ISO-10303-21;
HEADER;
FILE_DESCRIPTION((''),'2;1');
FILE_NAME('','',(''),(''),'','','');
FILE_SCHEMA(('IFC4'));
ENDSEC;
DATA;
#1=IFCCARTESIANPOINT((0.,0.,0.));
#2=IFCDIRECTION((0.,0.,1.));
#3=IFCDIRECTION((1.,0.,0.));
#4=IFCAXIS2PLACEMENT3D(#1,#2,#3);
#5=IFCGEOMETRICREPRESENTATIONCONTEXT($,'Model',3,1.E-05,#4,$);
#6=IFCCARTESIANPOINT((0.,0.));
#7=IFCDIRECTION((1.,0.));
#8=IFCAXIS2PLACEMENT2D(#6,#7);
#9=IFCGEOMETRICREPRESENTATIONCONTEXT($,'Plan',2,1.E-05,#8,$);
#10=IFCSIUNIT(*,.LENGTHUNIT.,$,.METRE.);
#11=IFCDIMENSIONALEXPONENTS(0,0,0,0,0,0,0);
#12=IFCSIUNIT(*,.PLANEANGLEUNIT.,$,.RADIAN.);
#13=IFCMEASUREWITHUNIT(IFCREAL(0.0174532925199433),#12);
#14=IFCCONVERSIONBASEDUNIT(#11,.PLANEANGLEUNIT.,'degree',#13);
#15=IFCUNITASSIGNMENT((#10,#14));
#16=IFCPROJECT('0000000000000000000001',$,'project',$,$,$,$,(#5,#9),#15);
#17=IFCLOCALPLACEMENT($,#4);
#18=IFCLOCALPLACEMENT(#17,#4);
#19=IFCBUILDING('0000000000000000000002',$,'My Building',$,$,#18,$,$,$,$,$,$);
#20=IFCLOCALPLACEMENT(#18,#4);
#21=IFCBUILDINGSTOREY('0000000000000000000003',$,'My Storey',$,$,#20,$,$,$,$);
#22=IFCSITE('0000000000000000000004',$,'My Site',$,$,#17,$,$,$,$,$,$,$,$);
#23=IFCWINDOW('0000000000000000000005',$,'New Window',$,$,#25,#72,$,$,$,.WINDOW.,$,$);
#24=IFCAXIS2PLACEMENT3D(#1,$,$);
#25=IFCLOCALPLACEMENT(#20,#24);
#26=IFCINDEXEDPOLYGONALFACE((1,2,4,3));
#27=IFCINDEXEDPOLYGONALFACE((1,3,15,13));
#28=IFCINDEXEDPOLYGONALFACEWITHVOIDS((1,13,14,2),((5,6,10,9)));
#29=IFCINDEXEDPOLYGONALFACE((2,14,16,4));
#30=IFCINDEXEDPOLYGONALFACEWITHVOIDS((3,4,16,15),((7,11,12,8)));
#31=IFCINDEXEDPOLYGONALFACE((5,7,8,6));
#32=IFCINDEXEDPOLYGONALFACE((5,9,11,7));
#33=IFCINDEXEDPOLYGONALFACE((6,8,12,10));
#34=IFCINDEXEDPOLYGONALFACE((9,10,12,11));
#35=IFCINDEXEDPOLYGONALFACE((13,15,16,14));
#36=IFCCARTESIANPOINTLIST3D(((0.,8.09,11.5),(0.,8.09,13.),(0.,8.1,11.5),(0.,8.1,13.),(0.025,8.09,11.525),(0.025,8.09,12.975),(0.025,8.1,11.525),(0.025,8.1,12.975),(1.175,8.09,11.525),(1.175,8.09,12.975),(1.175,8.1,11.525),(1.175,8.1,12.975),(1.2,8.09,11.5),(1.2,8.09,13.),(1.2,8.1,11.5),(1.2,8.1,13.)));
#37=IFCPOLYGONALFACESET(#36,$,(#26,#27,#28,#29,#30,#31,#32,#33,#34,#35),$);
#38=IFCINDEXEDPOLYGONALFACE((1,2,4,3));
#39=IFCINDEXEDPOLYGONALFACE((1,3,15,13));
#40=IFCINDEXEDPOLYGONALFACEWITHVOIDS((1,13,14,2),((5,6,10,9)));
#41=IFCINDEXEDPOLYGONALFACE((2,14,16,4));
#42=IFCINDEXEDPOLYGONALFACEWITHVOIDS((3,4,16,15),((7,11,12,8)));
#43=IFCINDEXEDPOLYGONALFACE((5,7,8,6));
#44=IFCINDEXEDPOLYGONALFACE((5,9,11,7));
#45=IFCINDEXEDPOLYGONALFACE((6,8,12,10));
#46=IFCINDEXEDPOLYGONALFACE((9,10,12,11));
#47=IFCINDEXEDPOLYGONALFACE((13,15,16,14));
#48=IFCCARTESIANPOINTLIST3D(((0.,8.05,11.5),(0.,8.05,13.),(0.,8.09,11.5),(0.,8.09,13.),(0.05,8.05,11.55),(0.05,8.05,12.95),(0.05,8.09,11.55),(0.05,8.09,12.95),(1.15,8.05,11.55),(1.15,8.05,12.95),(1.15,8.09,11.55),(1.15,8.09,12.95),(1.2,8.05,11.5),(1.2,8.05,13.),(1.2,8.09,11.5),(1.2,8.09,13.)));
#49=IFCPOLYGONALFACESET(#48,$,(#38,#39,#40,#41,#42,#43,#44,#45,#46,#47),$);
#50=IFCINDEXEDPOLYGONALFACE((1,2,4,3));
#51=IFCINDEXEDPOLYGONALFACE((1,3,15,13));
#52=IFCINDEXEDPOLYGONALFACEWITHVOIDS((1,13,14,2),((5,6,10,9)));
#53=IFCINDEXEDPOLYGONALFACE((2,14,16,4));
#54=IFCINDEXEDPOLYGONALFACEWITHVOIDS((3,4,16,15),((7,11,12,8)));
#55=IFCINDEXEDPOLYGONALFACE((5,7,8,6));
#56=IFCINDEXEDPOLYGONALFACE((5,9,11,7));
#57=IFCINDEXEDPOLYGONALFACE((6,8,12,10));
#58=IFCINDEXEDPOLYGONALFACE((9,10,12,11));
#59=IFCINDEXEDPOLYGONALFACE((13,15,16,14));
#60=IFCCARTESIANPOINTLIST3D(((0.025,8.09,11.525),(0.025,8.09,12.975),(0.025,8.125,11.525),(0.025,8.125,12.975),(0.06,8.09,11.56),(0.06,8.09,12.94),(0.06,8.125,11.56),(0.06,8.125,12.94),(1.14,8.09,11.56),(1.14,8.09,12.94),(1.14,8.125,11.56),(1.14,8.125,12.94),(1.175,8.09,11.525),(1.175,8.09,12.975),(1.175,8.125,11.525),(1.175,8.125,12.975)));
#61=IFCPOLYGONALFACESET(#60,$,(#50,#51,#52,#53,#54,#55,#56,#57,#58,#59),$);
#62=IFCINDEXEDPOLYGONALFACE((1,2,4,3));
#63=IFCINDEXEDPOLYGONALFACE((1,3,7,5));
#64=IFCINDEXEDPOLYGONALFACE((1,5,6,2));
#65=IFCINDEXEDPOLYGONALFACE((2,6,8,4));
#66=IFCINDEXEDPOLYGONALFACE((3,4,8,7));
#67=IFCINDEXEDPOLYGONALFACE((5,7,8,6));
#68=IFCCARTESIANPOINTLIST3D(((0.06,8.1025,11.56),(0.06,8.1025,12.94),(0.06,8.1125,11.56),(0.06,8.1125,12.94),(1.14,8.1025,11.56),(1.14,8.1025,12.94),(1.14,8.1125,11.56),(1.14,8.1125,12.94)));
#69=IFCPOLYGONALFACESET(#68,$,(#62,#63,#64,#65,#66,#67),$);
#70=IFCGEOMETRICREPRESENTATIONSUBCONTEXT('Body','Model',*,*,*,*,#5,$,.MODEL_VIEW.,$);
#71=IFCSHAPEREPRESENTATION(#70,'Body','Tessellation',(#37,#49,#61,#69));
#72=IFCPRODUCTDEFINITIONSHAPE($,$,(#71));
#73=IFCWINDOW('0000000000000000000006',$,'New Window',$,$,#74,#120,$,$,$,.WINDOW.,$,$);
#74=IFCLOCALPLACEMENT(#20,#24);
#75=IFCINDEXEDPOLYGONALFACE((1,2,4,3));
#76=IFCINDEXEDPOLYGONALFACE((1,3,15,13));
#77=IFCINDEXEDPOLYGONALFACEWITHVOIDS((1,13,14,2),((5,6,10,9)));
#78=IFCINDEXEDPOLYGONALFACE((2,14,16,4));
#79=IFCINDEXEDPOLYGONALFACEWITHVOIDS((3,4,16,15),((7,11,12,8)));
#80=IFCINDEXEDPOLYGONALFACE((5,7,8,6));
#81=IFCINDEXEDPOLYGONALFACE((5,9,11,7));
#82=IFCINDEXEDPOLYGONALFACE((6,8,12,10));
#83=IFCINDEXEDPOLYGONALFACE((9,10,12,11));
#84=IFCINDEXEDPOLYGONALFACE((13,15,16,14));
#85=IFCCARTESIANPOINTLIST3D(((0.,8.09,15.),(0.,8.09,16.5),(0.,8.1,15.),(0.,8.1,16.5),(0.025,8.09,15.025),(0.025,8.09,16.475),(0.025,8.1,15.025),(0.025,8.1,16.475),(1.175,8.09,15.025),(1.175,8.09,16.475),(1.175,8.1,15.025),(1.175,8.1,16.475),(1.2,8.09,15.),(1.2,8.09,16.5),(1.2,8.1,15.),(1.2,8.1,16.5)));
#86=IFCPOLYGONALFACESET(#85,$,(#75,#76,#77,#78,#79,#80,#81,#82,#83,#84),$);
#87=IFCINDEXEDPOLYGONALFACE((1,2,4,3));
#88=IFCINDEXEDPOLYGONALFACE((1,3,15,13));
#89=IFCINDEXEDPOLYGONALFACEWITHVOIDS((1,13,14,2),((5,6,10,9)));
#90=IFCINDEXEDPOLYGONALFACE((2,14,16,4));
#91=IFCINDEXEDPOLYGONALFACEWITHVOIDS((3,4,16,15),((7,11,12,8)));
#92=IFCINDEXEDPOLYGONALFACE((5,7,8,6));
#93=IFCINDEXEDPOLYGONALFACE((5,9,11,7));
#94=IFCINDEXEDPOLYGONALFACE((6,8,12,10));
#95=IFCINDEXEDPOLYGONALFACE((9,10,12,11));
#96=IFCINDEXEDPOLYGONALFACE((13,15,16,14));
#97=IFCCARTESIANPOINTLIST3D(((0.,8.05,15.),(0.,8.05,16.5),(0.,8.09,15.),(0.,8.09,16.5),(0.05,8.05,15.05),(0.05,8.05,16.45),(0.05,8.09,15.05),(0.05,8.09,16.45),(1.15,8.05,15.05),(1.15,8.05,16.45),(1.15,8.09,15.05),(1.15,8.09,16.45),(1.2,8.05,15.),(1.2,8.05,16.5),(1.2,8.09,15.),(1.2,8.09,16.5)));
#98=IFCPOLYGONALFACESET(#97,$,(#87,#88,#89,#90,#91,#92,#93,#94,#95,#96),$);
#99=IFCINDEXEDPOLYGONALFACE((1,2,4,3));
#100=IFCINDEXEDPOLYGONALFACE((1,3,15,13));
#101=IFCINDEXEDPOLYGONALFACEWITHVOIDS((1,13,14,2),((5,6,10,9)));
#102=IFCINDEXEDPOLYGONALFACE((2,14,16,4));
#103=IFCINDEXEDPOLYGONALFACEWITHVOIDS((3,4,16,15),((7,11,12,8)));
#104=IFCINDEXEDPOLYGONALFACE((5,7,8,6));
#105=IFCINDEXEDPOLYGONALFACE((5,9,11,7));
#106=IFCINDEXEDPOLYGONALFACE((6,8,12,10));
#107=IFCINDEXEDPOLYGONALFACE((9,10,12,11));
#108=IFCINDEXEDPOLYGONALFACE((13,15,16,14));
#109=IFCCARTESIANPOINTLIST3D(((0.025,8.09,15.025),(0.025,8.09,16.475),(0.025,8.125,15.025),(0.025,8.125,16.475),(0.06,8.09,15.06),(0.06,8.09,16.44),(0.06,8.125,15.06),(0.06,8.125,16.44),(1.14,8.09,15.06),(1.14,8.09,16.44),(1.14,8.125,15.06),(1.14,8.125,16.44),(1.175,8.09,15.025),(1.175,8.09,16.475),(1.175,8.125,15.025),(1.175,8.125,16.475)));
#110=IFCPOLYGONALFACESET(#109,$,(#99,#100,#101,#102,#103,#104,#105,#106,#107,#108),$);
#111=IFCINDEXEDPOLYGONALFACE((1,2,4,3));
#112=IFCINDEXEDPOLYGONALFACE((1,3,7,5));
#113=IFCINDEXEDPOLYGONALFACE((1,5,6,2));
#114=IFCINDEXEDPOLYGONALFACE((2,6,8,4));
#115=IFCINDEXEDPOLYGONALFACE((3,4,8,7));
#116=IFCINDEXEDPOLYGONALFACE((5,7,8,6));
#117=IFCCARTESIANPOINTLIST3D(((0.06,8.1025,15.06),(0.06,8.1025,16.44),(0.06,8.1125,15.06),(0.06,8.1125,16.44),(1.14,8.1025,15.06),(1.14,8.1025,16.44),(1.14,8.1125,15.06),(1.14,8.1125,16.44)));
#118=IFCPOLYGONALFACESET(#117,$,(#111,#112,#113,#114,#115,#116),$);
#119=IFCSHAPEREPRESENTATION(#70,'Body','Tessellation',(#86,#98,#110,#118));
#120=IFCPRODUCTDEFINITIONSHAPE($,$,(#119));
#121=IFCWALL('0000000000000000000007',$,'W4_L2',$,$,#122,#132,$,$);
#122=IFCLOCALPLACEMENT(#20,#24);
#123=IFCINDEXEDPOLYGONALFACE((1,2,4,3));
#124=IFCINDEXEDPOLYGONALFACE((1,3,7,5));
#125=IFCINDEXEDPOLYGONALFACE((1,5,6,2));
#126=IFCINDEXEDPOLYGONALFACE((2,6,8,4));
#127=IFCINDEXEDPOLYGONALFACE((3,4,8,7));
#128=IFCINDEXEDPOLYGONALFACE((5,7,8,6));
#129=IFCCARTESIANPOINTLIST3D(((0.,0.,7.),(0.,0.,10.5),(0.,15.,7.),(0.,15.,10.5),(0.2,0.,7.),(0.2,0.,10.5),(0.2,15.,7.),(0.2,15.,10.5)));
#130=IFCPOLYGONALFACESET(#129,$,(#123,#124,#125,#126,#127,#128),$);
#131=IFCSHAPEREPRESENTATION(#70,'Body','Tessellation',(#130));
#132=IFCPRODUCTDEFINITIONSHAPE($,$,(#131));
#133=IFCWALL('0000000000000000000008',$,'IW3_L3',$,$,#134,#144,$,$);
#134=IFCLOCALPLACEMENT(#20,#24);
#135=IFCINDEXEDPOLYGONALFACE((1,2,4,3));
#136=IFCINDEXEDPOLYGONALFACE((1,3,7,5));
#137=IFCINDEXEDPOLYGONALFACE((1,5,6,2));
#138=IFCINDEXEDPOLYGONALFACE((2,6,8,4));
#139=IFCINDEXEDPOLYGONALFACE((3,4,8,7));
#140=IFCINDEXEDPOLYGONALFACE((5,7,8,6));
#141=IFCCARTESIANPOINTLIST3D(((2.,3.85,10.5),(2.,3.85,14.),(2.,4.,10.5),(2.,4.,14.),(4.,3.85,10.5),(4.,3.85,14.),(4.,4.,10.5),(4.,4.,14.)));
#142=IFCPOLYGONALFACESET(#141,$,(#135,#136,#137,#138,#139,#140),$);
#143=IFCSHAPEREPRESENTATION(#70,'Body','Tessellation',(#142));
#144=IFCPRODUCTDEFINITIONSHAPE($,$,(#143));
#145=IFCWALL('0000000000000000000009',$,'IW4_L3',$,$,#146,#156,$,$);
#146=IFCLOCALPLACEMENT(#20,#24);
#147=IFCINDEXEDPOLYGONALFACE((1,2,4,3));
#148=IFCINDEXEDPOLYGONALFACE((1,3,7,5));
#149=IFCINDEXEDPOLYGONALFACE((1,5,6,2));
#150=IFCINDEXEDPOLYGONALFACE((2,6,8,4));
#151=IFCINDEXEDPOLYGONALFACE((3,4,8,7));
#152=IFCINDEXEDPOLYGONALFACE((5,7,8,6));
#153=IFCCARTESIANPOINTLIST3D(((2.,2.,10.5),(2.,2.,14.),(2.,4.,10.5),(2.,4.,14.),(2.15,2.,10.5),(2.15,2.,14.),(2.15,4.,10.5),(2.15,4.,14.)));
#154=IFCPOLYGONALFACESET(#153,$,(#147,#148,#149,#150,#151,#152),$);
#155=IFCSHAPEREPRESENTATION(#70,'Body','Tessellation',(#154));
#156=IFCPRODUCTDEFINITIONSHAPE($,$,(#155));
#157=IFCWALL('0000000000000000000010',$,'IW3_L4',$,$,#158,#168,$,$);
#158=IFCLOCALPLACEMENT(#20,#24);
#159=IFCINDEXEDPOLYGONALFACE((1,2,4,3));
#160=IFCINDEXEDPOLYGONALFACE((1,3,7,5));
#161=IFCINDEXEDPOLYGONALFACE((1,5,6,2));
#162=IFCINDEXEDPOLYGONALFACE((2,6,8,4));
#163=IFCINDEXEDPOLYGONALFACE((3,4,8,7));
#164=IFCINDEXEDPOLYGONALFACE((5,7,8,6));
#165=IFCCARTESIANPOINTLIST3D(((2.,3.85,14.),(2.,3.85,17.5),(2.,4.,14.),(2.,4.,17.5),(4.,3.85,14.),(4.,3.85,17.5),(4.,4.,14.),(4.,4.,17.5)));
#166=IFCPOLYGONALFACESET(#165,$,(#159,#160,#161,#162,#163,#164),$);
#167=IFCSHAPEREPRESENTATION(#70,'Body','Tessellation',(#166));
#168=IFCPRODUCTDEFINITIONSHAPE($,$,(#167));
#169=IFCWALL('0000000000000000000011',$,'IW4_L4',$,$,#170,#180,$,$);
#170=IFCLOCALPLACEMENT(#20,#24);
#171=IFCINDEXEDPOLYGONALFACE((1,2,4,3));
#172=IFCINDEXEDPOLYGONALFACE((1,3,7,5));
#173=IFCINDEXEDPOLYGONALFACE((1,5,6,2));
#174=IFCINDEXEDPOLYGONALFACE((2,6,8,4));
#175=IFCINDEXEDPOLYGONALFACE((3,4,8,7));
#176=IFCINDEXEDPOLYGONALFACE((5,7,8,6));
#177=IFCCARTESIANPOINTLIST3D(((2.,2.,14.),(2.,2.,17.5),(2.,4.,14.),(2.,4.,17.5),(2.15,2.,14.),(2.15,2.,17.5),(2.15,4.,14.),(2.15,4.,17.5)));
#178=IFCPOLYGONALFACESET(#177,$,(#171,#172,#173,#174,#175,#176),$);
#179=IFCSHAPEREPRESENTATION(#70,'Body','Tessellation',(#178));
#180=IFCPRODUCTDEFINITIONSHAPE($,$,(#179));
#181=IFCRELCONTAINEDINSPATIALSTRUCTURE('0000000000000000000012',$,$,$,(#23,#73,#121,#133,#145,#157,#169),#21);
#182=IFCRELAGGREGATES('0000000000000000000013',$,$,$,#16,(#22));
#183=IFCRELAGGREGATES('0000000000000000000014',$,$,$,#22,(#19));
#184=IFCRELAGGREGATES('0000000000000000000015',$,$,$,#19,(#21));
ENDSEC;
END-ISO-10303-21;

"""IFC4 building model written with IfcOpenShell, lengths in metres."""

from ifc_helpers import new_model, entity, si_unit, converted_unit, frame, origin_with_axes, origin_2d_with_axis, place, context, subcontext, project, spatial, line, indexed_curve, outline, extrude, element, save


model = new_model("IFC4")

# Units and contexts
model_context = context("Model", 3, precision=1e-05, world=origin_with_axes())
plan_context = context("Plan", 2, precision=1e-05, world=origin_2d_with_axis())
body_context = subcontext(model_context, "Body", "Model", "MODEL_VIEW")
ifc_project = project(units=[si_unit("LENGTHUNIT", "METRE"), converted_unit("PLANEANGLEUNIT", "degree", entity("IfcReal", 0.0174532925199433), si_unit("PLANEANGLEUNIT", "RADIAN"), dimensions=[0, 0, 0, 0, 0, 0, 0])], contexts=[model_context, plan_context])

# Site, building, storey
site_placement = place(None, origin_with_axes())
site = spatial("IfcSite", under=ifc_project, at=site_placement, Name="My Site")
building_placement = place(site_placement, origin_with_axes())
building = spatial("IfcBuilding", under=site, at=building_placement, Name="My Building")
storey_placement = place(building_placement, origin_with_axes())
storey = spatial("IfcBuildingStorey", under=building, at=storey_placement, Name="My Storey")

# Windows
for number, where, z_axis, x_axis, name in (
    (1, (0.0, 8.0, 11.5), (0.0, 0.0, 1.0), (1.0, 0.0, 0.0), "New Window"),
    (2, (0.0, 8.0, 15.0), (0.0, 0.0, 1.0), (1.0, 0.0, 0.0), "New Window"),
):
    element("IfcWindow", number, at=place(storey_placement, frame(where, z_axis=z_axis, x_axis=x_axis)), inside=storey, Name=name, PredefinedType="WINDOW", context=body_context, shape_type="SweptSolid", body=[
        extrude(outline(indexed_curve([(0.0, 0.0), (1.2, 0.0), (1.2, 1.5), (0.0, 1.5)], segments=[line(1, 2, 3, 4, 1)]), holes=[indexed_curve([(0.025, 0.025), (1.175, 0.025), (1.175, 1.475), (0.025, 1.475)], segments=[line(1, 2, 3, 4, 1)])]), frame((0.0, 0.09, 0.0), z_axis=(0.0, -1.0, 0.0), x_axis=(1.0, 0.0, 0.0)), (0.0, 0.0, -1.0), 0.01),
        extrude(outline(indexed_curve([(0.0, 0.0), (1.2, 0.0), (1.2, 1.5), (0.0, 1.5)], segments=[line(1, 2, 3, 4, 1)]), holes=[indexed_curve([(0.05, 0.05), (1.15, 0.05), (1.15, 1.45), (0.05, 1.45)], segments=[line(1, 2, 3, 4, 1)])]), frame((0.0, 0.05, 0.0), z_axis=(0.0, -1.0, 0.0), x_axis=(1.0, 0.0, 0.0)), (0.0, 0.0, -1.0), 0.04),
        extrude(outline(indexed_curve([(0.0, 0.0), (1.15, 0.0), (1.15, 1.45), (0.0, 1.45)], segments=[line(1, 2, 3, 4, 1)]), holes=[indexed_curve([(0.035, 0.035), (1.115, 0.035), (1.115, 1.415), (0.035, 1.415)], segments=[line(1, 2, 3, 4, 1)])]), frame((0.025, 0.09, 0.025), z_axis=(0.0, -1.0, 0.0), x_axis=(1.0, 0.0, 0.0)), (0.0, 0.0, -1.0), 0.035),
        extrude(outline(indexed_curve([(0.035, 0.035), (1.115, 0.035), (1.115, 1.415), (0.035, 1.415)], segments=[line(1, 2, 3, 4, 1)])), frame((0.025, 0.1025, 0.025), z_axis=(0.0, -1.0, 0.0), x_axis=(1.0, 0.0, 0.0)), (0.0, 0.0, -1.0), 0.01),
    ])

# Walls
for number, where, z_axis, x_axis, name in (
    (3, (0.0, 15.0, 7.0), (0.0, 0.0, 1.0), (0.0, -1.0, 0.0), "W4_L2"),
):
    element("IfcWall", number, at=place(storey_placement, frame(where, z_axis=z_axis, x_axis=x_axis)), inside=storey, Name=name, context=body_context, shape_type="SweptSolid", body=[
        extrude(outline(indexed_curve([(0.0, 0.0), (0.0, 0.2), (15.0, 0.2), (15.0, 0.0), (0.0, 0.0)], self_intersect=False)), origin_with_axes(), (0.0, 0.0, 1.0), 3.5),
    ])
for number, where, z_axis, x_axis, name in (
    (4, (4.0, 4.0, 10.5), (0.0, 0.0, 1.0), (-1.0, 0.0, 0.0), "IW3_L3"),
    (5, (2.0, 4.0, 10.5), (0.0, 0.0, 1.0), (0.0, -1.0, 0.0), "IW4_L3"),
):
    element("IfcWall", number, at=place(storey_placement, frame(where, z_axis=z_axis, x_axis=x_axis)), inside=storey, Name=name, context=body_context, shape_type="SweptSolid", body=[
        extrude(outline(indexed_curve([(0.0, 0.0), (0.0, 0.15), (2.0, 0.15), (2.0, 0.0), (0.0, 0.0)], self_intersect=False)), origin_with_axes(), (0.0, 0.0, 1.0), 3.5),
    ])
for number, where, z_axis, x_axis, name in (
    (6, (4.0, 4.0, 14.0), (0.0, 0.0, 1.0), (-1.0, 0.0, 0.0), "IW3_L4"),
    (7, (2.0, 4.0, 14.0), (0.0, 0.0, 1.0), (0.0, -1.0, 0.0), "IW4_L4"),
):
    element("IfcWall", number, at=place(storey_placement, frame(where, z_axis=z_axis, x_axis=x_axis)), inside=storey, Name=name, context=body_context, shape_type="SweptSolid", body=[
        extrude(outline(indexed_curve([(0.0, 0.0), (0.0, 0.15), (2.0, 0.15), (2.0, 0.0), (0.0, 0.0)], self_intersect=False)), origin_with_axes(), (0.0, 0.0, 1.0), 3.5),
    ])

save(model, "model.ifc")
